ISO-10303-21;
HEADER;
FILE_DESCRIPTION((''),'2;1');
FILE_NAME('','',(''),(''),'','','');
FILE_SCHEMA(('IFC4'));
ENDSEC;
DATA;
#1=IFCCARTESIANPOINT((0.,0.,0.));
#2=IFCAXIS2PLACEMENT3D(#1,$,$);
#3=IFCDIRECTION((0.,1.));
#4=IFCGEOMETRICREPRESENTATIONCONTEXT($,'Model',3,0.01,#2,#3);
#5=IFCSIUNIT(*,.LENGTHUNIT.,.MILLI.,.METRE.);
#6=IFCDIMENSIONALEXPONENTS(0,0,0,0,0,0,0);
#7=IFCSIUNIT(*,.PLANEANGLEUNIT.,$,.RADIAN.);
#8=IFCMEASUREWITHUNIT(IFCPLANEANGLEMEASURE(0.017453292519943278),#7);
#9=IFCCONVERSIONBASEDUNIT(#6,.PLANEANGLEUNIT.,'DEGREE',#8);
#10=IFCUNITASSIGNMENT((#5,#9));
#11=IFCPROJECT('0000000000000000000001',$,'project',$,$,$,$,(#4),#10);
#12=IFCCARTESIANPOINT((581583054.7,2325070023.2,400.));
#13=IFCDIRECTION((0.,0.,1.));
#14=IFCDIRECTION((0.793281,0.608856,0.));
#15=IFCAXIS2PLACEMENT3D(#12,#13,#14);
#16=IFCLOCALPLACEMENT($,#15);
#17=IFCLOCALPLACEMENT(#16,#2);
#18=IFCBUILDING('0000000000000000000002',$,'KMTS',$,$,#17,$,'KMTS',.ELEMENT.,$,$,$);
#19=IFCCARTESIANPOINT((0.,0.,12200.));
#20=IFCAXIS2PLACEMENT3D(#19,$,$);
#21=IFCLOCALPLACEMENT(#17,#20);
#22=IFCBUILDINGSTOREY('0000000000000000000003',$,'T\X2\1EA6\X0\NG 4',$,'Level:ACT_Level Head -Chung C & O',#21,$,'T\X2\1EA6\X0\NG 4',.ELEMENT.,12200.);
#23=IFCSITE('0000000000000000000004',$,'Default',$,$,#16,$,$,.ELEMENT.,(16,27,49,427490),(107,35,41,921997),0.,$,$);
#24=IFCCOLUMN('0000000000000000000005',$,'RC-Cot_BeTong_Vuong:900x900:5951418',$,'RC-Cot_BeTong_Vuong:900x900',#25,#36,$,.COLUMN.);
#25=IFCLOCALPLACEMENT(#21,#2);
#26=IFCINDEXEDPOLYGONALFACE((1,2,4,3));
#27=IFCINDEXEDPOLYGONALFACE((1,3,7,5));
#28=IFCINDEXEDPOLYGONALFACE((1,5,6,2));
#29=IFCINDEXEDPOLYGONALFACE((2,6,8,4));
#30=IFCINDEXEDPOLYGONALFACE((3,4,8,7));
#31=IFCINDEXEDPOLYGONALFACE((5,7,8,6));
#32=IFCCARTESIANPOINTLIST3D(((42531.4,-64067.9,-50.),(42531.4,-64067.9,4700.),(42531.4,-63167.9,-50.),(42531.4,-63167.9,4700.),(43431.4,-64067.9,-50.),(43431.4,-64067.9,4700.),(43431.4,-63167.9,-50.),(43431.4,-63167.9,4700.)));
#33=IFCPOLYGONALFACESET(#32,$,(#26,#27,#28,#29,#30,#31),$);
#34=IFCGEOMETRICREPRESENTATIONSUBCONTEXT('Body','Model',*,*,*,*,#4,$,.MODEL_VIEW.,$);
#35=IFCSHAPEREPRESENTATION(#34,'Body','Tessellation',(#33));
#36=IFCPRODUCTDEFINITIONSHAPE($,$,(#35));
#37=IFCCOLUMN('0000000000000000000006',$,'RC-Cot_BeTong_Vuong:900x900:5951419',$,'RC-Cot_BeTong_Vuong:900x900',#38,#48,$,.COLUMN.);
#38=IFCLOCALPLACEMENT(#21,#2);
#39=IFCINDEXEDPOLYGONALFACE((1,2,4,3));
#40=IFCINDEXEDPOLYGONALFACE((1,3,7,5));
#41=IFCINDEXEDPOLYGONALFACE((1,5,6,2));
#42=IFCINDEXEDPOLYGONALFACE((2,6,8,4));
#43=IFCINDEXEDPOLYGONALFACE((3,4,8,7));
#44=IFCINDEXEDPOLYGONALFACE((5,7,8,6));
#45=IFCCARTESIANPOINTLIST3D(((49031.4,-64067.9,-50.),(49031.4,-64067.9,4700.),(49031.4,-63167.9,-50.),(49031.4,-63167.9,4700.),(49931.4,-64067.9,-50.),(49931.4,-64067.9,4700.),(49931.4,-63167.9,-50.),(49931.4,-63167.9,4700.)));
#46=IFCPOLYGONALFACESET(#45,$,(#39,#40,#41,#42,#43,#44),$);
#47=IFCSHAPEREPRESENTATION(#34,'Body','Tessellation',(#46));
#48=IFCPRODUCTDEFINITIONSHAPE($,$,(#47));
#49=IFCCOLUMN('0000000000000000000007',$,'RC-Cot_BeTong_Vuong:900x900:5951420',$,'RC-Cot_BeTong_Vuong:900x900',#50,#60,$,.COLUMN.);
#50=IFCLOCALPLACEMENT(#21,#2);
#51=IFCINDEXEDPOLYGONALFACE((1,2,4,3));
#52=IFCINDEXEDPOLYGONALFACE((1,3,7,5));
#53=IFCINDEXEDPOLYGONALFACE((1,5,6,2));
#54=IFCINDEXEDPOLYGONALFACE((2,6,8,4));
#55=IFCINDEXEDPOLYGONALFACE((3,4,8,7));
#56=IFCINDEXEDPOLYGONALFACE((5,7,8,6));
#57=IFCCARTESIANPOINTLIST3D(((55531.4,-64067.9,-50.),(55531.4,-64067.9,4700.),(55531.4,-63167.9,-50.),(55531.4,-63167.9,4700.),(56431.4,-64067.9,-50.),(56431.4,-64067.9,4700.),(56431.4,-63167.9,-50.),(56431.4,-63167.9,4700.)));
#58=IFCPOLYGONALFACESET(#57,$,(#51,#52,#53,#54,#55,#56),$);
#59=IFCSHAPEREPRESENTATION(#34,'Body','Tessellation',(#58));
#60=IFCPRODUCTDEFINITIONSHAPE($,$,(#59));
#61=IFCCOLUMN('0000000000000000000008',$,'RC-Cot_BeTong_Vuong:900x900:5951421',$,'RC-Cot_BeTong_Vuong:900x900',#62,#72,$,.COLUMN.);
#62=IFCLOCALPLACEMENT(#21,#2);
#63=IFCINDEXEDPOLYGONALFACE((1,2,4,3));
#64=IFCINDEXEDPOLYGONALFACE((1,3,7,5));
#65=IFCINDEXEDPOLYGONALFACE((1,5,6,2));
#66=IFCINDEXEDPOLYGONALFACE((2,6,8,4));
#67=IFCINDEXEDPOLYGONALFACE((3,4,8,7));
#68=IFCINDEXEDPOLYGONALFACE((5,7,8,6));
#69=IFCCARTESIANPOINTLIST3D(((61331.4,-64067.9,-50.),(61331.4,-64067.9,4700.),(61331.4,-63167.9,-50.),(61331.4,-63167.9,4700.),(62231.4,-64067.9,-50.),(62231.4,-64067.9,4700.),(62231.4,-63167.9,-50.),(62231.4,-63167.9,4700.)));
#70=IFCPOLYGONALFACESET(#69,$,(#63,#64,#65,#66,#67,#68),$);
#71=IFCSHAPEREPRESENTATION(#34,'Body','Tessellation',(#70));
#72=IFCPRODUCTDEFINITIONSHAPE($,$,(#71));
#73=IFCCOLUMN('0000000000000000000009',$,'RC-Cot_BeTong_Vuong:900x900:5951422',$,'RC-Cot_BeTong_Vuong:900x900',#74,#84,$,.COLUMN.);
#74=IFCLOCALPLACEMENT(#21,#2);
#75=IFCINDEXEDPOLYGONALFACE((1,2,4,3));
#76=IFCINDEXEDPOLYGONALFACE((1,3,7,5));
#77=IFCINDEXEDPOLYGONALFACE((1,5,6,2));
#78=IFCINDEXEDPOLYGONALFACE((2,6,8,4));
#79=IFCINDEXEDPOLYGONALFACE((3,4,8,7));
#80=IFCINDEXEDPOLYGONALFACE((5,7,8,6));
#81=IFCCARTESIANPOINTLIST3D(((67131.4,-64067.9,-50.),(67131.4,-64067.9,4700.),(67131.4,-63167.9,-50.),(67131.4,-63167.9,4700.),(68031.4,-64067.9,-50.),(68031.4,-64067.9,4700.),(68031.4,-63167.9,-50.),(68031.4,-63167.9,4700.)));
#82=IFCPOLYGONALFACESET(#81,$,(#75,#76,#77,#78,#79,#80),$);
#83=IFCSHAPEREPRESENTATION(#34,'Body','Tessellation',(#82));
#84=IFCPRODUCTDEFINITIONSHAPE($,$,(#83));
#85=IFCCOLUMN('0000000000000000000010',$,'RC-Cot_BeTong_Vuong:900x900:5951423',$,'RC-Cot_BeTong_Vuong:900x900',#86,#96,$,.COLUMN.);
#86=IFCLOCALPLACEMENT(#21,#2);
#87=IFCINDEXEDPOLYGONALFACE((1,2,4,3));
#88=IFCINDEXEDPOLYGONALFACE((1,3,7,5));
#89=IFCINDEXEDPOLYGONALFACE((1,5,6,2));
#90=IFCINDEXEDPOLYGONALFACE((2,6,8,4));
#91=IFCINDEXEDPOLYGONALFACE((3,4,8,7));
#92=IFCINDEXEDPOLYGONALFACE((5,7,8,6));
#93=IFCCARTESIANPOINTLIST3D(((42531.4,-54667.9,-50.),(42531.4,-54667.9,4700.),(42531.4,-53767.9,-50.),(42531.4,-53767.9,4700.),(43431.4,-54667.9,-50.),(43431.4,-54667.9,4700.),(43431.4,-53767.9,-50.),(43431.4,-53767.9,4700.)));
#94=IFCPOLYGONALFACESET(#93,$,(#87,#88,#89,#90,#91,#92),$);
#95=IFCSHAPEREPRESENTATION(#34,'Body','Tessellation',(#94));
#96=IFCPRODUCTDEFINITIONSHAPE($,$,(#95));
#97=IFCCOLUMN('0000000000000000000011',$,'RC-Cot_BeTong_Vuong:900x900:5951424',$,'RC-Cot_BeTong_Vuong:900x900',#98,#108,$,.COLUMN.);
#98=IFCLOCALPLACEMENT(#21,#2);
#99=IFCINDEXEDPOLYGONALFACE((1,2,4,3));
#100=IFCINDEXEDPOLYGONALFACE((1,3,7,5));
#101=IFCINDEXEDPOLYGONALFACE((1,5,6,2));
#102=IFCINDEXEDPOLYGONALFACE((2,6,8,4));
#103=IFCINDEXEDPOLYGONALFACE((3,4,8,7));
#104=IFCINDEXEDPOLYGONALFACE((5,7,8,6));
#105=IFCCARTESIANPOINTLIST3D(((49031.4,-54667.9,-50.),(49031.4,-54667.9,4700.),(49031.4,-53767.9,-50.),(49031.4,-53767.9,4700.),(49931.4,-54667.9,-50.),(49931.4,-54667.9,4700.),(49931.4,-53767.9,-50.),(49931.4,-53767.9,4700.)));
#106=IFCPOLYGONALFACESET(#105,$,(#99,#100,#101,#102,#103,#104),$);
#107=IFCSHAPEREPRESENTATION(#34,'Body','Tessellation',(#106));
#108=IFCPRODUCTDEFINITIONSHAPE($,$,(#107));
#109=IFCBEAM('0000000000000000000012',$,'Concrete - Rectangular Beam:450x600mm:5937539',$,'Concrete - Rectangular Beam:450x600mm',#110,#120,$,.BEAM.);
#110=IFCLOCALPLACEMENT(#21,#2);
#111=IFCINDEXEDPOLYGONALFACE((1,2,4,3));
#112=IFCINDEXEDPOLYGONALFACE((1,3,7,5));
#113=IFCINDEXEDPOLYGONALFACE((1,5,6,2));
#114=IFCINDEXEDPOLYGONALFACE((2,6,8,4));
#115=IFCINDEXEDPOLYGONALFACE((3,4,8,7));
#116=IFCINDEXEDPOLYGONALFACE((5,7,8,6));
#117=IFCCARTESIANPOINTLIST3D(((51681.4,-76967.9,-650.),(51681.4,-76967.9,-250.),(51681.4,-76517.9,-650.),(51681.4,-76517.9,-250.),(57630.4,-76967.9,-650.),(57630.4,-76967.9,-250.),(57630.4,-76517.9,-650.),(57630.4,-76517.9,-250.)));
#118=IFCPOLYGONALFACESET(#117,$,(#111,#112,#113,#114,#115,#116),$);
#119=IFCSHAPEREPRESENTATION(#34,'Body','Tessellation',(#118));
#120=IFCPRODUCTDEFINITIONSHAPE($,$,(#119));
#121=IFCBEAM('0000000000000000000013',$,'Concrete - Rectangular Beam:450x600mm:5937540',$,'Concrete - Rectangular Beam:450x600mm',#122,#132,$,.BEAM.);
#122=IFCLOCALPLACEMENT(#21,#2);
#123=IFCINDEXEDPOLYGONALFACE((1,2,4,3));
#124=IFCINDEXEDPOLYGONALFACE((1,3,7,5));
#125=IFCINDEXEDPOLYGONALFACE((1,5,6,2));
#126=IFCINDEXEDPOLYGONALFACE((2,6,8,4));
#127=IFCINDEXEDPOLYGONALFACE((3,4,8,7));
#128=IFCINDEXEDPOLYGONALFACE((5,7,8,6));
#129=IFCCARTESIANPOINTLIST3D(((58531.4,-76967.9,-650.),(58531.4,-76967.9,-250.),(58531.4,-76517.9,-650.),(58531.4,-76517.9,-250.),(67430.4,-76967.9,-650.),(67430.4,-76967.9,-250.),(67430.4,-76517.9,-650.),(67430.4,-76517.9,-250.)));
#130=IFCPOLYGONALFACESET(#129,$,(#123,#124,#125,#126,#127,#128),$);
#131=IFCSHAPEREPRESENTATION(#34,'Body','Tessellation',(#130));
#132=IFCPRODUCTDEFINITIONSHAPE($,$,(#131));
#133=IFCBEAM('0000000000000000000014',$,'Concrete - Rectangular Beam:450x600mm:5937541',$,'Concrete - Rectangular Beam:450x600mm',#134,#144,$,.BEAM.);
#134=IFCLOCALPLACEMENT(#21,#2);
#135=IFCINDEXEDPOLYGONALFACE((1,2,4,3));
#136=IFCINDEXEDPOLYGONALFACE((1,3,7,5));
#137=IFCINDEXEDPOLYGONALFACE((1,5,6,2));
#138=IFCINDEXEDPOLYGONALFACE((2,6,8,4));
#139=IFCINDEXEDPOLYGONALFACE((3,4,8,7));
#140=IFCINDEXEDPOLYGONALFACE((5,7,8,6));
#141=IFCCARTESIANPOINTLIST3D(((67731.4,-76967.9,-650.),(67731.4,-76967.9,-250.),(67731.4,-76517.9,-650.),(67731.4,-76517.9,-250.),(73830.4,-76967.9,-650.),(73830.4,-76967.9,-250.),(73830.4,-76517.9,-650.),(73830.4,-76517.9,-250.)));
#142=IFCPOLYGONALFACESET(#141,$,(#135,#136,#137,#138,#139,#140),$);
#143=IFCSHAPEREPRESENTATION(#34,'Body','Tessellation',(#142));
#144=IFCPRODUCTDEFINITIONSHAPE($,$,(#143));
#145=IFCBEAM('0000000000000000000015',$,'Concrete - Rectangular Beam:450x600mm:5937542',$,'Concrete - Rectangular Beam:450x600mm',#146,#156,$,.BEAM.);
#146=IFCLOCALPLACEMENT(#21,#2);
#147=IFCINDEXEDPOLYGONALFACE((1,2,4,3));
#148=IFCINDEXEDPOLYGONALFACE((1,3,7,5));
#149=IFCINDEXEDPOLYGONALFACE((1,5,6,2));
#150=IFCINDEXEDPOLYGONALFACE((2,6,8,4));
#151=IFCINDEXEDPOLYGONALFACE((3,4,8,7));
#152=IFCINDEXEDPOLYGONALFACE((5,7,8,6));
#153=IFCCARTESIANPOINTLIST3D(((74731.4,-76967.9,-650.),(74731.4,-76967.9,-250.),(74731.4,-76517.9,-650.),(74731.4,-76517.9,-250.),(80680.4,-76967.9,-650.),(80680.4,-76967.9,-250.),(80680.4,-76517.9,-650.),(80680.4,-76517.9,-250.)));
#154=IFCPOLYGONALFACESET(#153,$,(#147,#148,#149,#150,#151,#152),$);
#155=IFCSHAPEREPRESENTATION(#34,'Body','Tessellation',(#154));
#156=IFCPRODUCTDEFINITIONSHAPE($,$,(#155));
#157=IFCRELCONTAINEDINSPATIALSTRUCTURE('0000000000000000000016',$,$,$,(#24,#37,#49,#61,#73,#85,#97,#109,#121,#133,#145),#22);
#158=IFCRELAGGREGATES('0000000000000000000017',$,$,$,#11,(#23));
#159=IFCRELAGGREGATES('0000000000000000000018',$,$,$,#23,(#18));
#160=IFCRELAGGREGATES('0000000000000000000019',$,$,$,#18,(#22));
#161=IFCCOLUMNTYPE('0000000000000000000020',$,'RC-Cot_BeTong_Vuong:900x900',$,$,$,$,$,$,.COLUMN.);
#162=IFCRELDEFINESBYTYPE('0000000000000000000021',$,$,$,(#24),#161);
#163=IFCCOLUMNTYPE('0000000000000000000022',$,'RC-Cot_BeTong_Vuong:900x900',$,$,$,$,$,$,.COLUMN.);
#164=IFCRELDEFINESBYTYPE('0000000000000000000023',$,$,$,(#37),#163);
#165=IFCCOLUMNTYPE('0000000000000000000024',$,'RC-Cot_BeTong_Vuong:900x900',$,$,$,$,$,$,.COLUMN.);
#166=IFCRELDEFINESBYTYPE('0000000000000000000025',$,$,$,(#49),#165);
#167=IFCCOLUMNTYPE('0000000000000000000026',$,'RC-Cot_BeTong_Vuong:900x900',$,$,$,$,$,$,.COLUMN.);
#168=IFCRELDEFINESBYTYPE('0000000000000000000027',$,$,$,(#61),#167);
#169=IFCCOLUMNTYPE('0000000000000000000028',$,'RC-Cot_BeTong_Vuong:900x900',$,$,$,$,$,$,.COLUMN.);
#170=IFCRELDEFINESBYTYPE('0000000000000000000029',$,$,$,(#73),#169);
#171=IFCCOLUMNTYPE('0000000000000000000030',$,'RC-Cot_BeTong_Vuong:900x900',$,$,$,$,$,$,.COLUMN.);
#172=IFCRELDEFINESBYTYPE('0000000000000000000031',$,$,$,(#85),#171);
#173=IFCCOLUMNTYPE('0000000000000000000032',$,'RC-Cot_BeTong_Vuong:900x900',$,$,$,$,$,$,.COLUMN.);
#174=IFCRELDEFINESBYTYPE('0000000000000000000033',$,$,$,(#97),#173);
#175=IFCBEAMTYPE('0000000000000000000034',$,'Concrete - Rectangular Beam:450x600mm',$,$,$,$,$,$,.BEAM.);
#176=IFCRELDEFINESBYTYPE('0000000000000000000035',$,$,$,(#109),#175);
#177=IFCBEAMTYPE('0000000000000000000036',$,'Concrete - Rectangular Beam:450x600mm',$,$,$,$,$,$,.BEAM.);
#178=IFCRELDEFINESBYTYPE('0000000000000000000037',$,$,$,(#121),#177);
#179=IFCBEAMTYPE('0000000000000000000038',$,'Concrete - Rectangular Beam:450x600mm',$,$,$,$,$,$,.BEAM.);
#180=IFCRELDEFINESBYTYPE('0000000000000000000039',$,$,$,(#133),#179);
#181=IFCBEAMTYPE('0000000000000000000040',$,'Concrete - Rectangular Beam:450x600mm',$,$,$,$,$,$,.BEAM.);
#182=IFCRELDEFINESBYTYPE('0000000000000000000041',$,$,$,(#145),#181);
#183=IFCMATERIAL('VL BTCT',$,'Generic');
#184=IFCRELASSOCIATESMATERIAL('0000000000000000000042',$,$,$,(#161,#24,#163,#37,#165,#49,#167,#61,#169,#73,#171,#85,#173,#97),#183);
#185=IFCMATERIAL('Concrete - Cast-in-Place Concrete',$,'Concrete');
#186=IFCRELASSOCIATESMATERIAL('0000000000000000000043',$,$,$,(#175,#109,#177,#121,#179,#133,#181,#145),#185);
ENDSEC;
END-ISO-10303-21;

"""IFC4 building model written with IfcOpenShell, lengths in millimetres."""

from ifc_helpers import new_model, entity, si_unit, converted_unit, direction, frame, origin, place, context, subcontext, project, spatial, indexed_curve, outline, extrude, source, transform, mapped, material, type_object, type_shapes, element, save


model = new_model("IFC4")

# Units and contexts
model_context = context("Model", 3, precision=0.01, world=origin(), true_north=direction((0.0, 1.0)))
body_context = subcontext(model_context, "Body", "Model", "MODEL_VIEW")
ifc_project = project(units=[si_unit("LENGTHUNIT", "METRE", prefix="MILLI"), converted_unit("PLANEANGLEUNIT", "DEGREE", entity("IfcPlaneAngleMeasure", 0.017453292519943278), si_unit("PLANEANGLEUNIT", "RADIAN"), dimensions=[0, 0, 0, 0, 0, 0, 0])], contexts=[model_context])

# Site, building, storey
site_placement = place(None, frame((581583054.7, 2325070023.2, 400.0), z_axis=(0.0, 0.0, 1.0), x_axis=(0.793281, 0.608856, 0.0)))
site = spatial("IfcSite", under=ifc_project, at=site_placement, Name="Default", CompositionType="ELEMENT", RefLatitude=(16, 27, 49, 427490), RefLongitude=(107, 35, 41, 921997), RefElevation=0.0)
building_placement = place(site_placement, origin())
building = spatial("IfcBuilding", under=site, at=building_placement, Name="KMTS", LongName="KMTS", CompositionType="ELEMENT")
storey_placement = place(building_placement, frame((0.0, 0.0, 12200.0)))
storey = spatial("IfcBuildingStorey", under=building, at=storey_placement, Name="TẦNG 4", ObjectType="Level:ACT_Level Head -Chung C & O", LongName="TẦNG 4", CompositionType="ELEMENT", Elevation=12200.0)

# Columns
ifc_material_1 = material(Name="VL BTCT", Category="Generic")
column_type_1 = type_object("IfcColumnType", Name="RC-Cot_BeTong_Vuong:900x900", PredefinedType="COLUMN", material=ifc_material_1)
shared_shape_1 = source(origin(), body_context, "Body", "SweptSolid", [
    extrude(outline(indexed_curve([(-450.0, -450.0), (450.0, -450.0), (450.0, 450.0), (-450.0, 450.0), (-450.0, -450.0)], self_intersect=False)), frame((42981.4, -63617.9, 12150.0), z_axis=(0.0, 0.0, 1.0), x_axis=(-1.0, 0.0, 0.0)), (0.0, 0.0, 1.0), 4750.0),
])
type_shapes(column_type_1, [shared_shape_1])
column_1_placement = place(storey_placement, frame((0.0, 0.0, -12200.0)))
element("IfcColumn", 1, at=column_1_placement, inside=storey, type_object=column_type_1, material=ifc_material_1, Name="RC-Cot_BeTong_Vuong:900x900:5951418", ObjectType="RC-Cot_BeTong_Vuong:900x900", PredefinedType="COLUMN", context=body_context, shape_type="MappedRepresentation", body=[
    mapped(shared_shape_1, transform((0.0, 0.0, 0.0), scale=1.0)),
])
column_type_2 = type_object("IfcColumnType", Name="RC-Cot_BeTong_Vuong:900x900", PredefinedType="COLUMN", material=ifc_material_1)
shared_shape_2 = source(origin(), body_context, "Body", "SweptSolid", [
    extrude(outline(indexed_curve([(-450.0, -450.0), (450.0, -450.0), (450.0, 450.0), (-450.0, 450.0), (-450.0, -450.0)], self_intersect=False)), frame((49481.4, -63617.9, 12150.0), z_axis=(0.0, 0.0, 1.0), x_axis=(-1.0, 0.0, 0.0)), (0.0, 0.0, 1.0), 4750.0),
])
type_shapes(column_type_2, [shared_shape_2])
column_2_placement = place(storey_placement, frame((0.0, 0.0, -12200.0)))
element("IfcColumn", 2, at=column_2_placement, inside=storey, type_object=column_type_2, material=ifc_material_1, Name="RC-Cot_BeTong_Vuong:900x900:5951419", ObjectType="RC-Cot_BeTong_Vuong:900x900", PredefinedType="COLUMN", context=body_context, shape_type="MappedRepresentation", body=[
    mapped(shared_shape_2, transform((0.0, 0.0, 0.0), scale=1.0)),
])
column_type_3 = type_object("IfcColumnType", Name="RC-Cot_BeTong_Vuong:900x900", PredefinedType="COLUMN", material=ifc_material_1)
shared_shape_3 = source(origin(), body_context, "Body", "SweptSolid", [
    extrude(outline(indexed_curve([(-450.0, -450.0), (450.0, -450.0), (450.0, 450.0), (-450.0, 450.0), (-450.0, -450.0)], self_intersect=False)), frame((55981.4, -63617.9, 12150.0), z_axis=(0.0, 0.0, 1.0), x_axis=(-1.0, 0.0, 0.0)), (0.0, 0.0, 1.0), 4750.0),
])
type_shapes(column_type_3, [shared_shape_3])
column_3_placement = place(storey_placement, frame((0.0, 0.0, -12200.0)))
element("IfcColumn", 3, at=column_3_placement, inside=storey, type_object=column_type_3, material=ifc_material_1, Name="RC-Cot_BeTong_Vuong:900x900:5951420", ObjectType="RC-Cot_BeTong_Vuong:900x900", PredefinedType="COLUMN", context=body_context, shape_type="MappedRepresentation", body=[
    mapped(shared_shape_3, transform((0.0, 0.0, 0.0), scale=1.0)),
])
column_type_4 = type_object("IfcColumnType", Name="RC-Cot_BeTong_Vuong:900x900", PredefinedType="COLUMN", material=ifc_material_1)
shared_shape_4 = source(origin(), body_context, "Body", "SweptSolid", [
    extrude(outline(indexed_curve([(-450.0, -450.0), (450.0, -450.0), (450.0, 450.0), (-450.0, 450.0), (-450.0, -450.0)], self_intersect=False)), frame((61781.4, -63617.9, 12150.0), z_axis=(0.0, 0.0, 1.0), x_axis=(-1.0, 0.0, 0.0)), (0.0, 0.0, 1.0), 4750.0),
])
type_shapes(column_type_4, [shared_shape_4])
column_4_placement = place(storey_placement, frame((0.0, 0.0, -12200.0)))
element("IfcColumn", 4, at=column_4_placement, inside=storey, type_object=column_type_4, material=ifc_material_1, Name="RC-Cot_BeTong_Vuong:900x900:5951421", ObjectType="RC-Cot_BeTong_Vuong:900x900", PredefinedType="COLUMN", context=body_context, shape_type="MappedRepresentation", body=[
    mapped(shared_shape_4, transform((0.0, 0.0, 0.0), scale=1.0)),
])
column_type_5 = type_object("IfcColumnType", Name="RC-Cot_BeTong_Vuong:900x900", PredefinedType="COLUMN", material=ifc_material_1)
shared_shape_5 = source(origin(), body_context, "Body", "SweptSolid", [
    extrude(outline(indexed_curve([(-450.0, -450.0), (450.0, -450.0), (450.0, 450.0), (-450.0, 450.0), (-450.0, -450.0)], self_intersect=False)), frame((67581.4, -63617.9, 12150.0), z_axis=(0.0, 0.0, 1.0), x_axis=(-1.0, 0.0, 0.0)), (0.0, 0.0, 1.0), 4750.0),
])
type_shapes(column_type_5, [shared_shape_5])
column_5_placement = place(storey_placement, frame((0.0, 0.0, -12200.0)))
element("IfcColumn", 5, at=column_5_placement, inside=storey, type_object=column_type_5, material=ifc_material_1, Name="RC-Cot_BeTong_Vuong:900x900:5951422", ObjectType="RC-Cot_BeTong_Vuong:900x900", PredefinedType="COLUMN", context=body_context, shape_type="MappedRepresentation", body=[
    mapped(shared_shape_5, transform((0.0, 0.0, 0.0), scale=1.0)),
])
column_type_6 = type_object("IfcColumnType", Name="RC-Cot_BeTong_Vuong:900x900", PredefinedType="COLUMN", material=ifc_material_1)
shared_shape_6 = source(origin(), body_context, "Body", "SweptSolid", [
    extrude(outline(indexed_curve([(-450.0, -450.0), (450.0, -450.0), (450.0, 450.0), (-450.0, 450.0), (-450.0, -450.0)], self_intersect=False)), frame((42981.4, -54217.9, 12150.0), z_axis=(0.0, 0.0, 1.0), x_axis=(-1.0, 0.0, 0.0)), (0.0, 0.0, 1.0), 4750.0),
])
type_shapes(column_type_6, [shared_shape_6])
column_6_placement = place(storey_placement, frame((0.0, 0.0, -12200.0)))
element("IfcColumn", 6, at=column_6_placement, inside=storey, type_object=column_type_6, material=ifc_material_1, Name="RC-Cot_BeTong_Vuong:900x900:5951423", ObjectType="RC-Cot_BeTong_Vuong:900x900", PredefinedType="COLUMN", context=body_context, shape_type="MappedRepresentation", body=[
    mapped(shared_shape_6, transform((0.0, 0.0, 0.0), scale=1.0)),
])
column_type_7 = type_object("IfcColumnType", Name="RC-Cot_BeTong_Vuong:900x900", PredefinedType="COLUMN", material=ifc_material_1)
shared_shape_7 = source(origin(), body_context, "Body", "SweptSolid", [
    extrude(outline(indexed_curve([(-450.0, -450.0), (450.0, -450.0), (450.0, 450.0), (-450.0, 450.0), (-450.0, -450.0)], self_intersect=False)), frame((49481.4, -54217.9, 12150.0), z_axis=(0.0, 0.0, 1.0), x_axis=(-1.0, 0.0, 0.0)), (0.0, 0.0, 1.0), 4750.0),
])
type_shapes(column_type_7, [shared_shape_7])
column_7_placement = place(storey_placement, frame((0.0, 0.0, -12200.0)))
element("IfcColumn", 7, at=column_7_placement, inside=storey, type_object=column_type_7, material=ifc_material_1, Name="RC-Cot_BeTong_Vuong:900x900:5951424", ObjectType="RC-Cot_BeTong_Vuong:900x900", PredefinedType="COLUMN", context=body_context, shape_type="MappedRepresentation", body=[
    mapped(shared_shape_7, transform((0.0, 0.0, 0.0), scale=1.0)),
])

# Beams
ifc_material_2 = material(Name="Concrete - Cast-in-Place Concrete", Category="Concrete")
beam_type_1 = type_object("IfcBeamType", Name="Concrete - Rectangular Beam:450x600mm", PredefinedType="BEAM", material=ifc_material_2)
shared_shape_8 = source(origin(), body_context, "Body", "SweptSolid", [
    extrude(outline(indexed_curve([(-200.0, -225.0), (200.0, -225.0), (200.0, 225.0), (-200.0, 225.0), (-200.0, -225.0)], self_intersect=False)), frame((51681.4, -76742.9, 11750.0), z_axis=(1.0, 0.0, 0.0), x_axis=(0.0, 0.0, -1.0)), (0.0, 0.0, 1.0), 5949.0),
])
type_shapes(beam_type_1, [shared_shape_8])
beam_1_placement = place(storey_placement, frame((0.0, 0.0, -12200.0)))
element("IfcBeam", 8, at=beam_1_placement, inside=storey, type_object=beam_type_1, material=ifc_material_2, Name="Concrete - Rectangular Beam:450x600mm:5937539", ObjectType="Concrete - Rectangular Beam:450x600mm", PredefinedType="BEAM", context=body_context, shape_type="MappedRepresentation", body=[
    mapped(shared_shape_8, transform((0.0, 0.0, 0.0), scale=1.0)),
])
beam_type_2 = type_object("IfcBeamType", Name="Concrete - Rectangular Beam:450x600mm", PredefinedType="BEAM", material=ifc_material_2)
shared_shape_9 = source(origin(), body_context, "Body", "SweptSolid", [
    extrude(outline(indexed_curve([(-200.0, -225.0), (200.0, -225.0), (200.0, 225.0), (-200.0, 225.0), (-200.0, -225.0)], self_intersect=False)), frame((67430.4, -76742.9, 11750.0), z_axis=(-1.0, 0.0, 0.0), x_axis=(0.0, 0.0, -1.0)), (0.0, 0.0, 1.0), 8899.0),
])
type_shapes(beam_type_2, [shared_shape_9])
beam_2_placement = place(storey_placement, frame((0.0, 0.0, -12200.0)))
element("IfcBeam", 9, at=beam_2_placement, inside=storey, type_object=beam_type_2, material=ifc_material_2, Name="Concrete - Rectangular Beam:450x600mm:5937540", ObjectType="Concrete - Rectangular Beam:450x600mm", PredefinedType="BEAM", context=body_context, shape_type="MappedRepresentation", body=[
    mapped(shared_shape_9, transform((0.0, 0.0, 0.0), scale=1.0)),
])
beam_type_3 = type_object("IfcBeamType", Name="Concrete - Rectangular Beam:450x600mm", PredefinedType="BEAM", material=ifc_material_2)
shared_shape_10 = source(origin(), body_context, "Body", "SweptSolid", [
    extrude(outline(indexed_curve([(-200.0, -225.0), (200.0, -225.0), (200.0, 225.0), (-200.0, 225.0), (-200.0, -225.0)], self_intersect=False)), frame((67731.4, -76742.9, 11750.0), z_axis=(1.0, 0.0, 0.0), x_axis=(0.0, 0.0, -1.0)), (0.0, 0.0, 1.0), 6099.0),
])
type_shapes(beam_type_3, [shared_shape_10])
beam_3_placement = place(storey_placement, frame((0.0, 0.0, -12200.0)))
element("IfcBeam", 10, at=beam_3_placement, inside=storey, type_object=beam_type_3, material=ifc_material_2, Name="Concrete - Rectangular Beam:450x600mm:5937541", ObjectType="Concrete - Rectangular Beam:450x600mm", PredefinedType="BEAM", context=body_context, shape_type="MappedRepresentation", body=[
    mapped(shared_shape_10, transform((0.0, 0.0, 0.0), scale=1.0)),
])
beam_type_4 = type_object("IfcBeamType", Name="Concrete - Rectangular Beam:450x600mm", PredefinedType="BEAM", material=ifc_material_2)
shared_shape_11 = source(origin(), body_context, "Body", "SweptSolid", [
    extrude(outline(indexed_curve([(-200.0, -225.0), (200.0, -225.0), (200.0, 225.0), (-200.0, 225.0), (-200.0, -225.0)], self_intersect=False)), frame((74731.4, -76742.9, 11750.0), z_axis=(1.0, 0.0, 0.0), x_axis=(0.0, 0.0, -1.0)), (0.0, 0.0, 1.0), 5949.0),
])
type_shapes(beam_type_4, [shared_shape_11])
beam_4_placement = place(storey_placement, frame((0.0, 0.0, -12200.0)))
element("IfcBeam", 11, at=beam_4_placement, inside=storey, type_object=beam_type_4, material=ifc_material_2, Name="Concrete - Rectangular Beam:450x600mm:5937542", ObjectType="Concrete - Rectangular Beam:450x600mm", PredefinedType="BEAM", context=body_context, shape_type="MappedRepresentation", body=[
    mapped(shared_shape_11, transform((0.0, 0.0, 0.0), scale=1.0)),
])

save(model, "model.ifc")
